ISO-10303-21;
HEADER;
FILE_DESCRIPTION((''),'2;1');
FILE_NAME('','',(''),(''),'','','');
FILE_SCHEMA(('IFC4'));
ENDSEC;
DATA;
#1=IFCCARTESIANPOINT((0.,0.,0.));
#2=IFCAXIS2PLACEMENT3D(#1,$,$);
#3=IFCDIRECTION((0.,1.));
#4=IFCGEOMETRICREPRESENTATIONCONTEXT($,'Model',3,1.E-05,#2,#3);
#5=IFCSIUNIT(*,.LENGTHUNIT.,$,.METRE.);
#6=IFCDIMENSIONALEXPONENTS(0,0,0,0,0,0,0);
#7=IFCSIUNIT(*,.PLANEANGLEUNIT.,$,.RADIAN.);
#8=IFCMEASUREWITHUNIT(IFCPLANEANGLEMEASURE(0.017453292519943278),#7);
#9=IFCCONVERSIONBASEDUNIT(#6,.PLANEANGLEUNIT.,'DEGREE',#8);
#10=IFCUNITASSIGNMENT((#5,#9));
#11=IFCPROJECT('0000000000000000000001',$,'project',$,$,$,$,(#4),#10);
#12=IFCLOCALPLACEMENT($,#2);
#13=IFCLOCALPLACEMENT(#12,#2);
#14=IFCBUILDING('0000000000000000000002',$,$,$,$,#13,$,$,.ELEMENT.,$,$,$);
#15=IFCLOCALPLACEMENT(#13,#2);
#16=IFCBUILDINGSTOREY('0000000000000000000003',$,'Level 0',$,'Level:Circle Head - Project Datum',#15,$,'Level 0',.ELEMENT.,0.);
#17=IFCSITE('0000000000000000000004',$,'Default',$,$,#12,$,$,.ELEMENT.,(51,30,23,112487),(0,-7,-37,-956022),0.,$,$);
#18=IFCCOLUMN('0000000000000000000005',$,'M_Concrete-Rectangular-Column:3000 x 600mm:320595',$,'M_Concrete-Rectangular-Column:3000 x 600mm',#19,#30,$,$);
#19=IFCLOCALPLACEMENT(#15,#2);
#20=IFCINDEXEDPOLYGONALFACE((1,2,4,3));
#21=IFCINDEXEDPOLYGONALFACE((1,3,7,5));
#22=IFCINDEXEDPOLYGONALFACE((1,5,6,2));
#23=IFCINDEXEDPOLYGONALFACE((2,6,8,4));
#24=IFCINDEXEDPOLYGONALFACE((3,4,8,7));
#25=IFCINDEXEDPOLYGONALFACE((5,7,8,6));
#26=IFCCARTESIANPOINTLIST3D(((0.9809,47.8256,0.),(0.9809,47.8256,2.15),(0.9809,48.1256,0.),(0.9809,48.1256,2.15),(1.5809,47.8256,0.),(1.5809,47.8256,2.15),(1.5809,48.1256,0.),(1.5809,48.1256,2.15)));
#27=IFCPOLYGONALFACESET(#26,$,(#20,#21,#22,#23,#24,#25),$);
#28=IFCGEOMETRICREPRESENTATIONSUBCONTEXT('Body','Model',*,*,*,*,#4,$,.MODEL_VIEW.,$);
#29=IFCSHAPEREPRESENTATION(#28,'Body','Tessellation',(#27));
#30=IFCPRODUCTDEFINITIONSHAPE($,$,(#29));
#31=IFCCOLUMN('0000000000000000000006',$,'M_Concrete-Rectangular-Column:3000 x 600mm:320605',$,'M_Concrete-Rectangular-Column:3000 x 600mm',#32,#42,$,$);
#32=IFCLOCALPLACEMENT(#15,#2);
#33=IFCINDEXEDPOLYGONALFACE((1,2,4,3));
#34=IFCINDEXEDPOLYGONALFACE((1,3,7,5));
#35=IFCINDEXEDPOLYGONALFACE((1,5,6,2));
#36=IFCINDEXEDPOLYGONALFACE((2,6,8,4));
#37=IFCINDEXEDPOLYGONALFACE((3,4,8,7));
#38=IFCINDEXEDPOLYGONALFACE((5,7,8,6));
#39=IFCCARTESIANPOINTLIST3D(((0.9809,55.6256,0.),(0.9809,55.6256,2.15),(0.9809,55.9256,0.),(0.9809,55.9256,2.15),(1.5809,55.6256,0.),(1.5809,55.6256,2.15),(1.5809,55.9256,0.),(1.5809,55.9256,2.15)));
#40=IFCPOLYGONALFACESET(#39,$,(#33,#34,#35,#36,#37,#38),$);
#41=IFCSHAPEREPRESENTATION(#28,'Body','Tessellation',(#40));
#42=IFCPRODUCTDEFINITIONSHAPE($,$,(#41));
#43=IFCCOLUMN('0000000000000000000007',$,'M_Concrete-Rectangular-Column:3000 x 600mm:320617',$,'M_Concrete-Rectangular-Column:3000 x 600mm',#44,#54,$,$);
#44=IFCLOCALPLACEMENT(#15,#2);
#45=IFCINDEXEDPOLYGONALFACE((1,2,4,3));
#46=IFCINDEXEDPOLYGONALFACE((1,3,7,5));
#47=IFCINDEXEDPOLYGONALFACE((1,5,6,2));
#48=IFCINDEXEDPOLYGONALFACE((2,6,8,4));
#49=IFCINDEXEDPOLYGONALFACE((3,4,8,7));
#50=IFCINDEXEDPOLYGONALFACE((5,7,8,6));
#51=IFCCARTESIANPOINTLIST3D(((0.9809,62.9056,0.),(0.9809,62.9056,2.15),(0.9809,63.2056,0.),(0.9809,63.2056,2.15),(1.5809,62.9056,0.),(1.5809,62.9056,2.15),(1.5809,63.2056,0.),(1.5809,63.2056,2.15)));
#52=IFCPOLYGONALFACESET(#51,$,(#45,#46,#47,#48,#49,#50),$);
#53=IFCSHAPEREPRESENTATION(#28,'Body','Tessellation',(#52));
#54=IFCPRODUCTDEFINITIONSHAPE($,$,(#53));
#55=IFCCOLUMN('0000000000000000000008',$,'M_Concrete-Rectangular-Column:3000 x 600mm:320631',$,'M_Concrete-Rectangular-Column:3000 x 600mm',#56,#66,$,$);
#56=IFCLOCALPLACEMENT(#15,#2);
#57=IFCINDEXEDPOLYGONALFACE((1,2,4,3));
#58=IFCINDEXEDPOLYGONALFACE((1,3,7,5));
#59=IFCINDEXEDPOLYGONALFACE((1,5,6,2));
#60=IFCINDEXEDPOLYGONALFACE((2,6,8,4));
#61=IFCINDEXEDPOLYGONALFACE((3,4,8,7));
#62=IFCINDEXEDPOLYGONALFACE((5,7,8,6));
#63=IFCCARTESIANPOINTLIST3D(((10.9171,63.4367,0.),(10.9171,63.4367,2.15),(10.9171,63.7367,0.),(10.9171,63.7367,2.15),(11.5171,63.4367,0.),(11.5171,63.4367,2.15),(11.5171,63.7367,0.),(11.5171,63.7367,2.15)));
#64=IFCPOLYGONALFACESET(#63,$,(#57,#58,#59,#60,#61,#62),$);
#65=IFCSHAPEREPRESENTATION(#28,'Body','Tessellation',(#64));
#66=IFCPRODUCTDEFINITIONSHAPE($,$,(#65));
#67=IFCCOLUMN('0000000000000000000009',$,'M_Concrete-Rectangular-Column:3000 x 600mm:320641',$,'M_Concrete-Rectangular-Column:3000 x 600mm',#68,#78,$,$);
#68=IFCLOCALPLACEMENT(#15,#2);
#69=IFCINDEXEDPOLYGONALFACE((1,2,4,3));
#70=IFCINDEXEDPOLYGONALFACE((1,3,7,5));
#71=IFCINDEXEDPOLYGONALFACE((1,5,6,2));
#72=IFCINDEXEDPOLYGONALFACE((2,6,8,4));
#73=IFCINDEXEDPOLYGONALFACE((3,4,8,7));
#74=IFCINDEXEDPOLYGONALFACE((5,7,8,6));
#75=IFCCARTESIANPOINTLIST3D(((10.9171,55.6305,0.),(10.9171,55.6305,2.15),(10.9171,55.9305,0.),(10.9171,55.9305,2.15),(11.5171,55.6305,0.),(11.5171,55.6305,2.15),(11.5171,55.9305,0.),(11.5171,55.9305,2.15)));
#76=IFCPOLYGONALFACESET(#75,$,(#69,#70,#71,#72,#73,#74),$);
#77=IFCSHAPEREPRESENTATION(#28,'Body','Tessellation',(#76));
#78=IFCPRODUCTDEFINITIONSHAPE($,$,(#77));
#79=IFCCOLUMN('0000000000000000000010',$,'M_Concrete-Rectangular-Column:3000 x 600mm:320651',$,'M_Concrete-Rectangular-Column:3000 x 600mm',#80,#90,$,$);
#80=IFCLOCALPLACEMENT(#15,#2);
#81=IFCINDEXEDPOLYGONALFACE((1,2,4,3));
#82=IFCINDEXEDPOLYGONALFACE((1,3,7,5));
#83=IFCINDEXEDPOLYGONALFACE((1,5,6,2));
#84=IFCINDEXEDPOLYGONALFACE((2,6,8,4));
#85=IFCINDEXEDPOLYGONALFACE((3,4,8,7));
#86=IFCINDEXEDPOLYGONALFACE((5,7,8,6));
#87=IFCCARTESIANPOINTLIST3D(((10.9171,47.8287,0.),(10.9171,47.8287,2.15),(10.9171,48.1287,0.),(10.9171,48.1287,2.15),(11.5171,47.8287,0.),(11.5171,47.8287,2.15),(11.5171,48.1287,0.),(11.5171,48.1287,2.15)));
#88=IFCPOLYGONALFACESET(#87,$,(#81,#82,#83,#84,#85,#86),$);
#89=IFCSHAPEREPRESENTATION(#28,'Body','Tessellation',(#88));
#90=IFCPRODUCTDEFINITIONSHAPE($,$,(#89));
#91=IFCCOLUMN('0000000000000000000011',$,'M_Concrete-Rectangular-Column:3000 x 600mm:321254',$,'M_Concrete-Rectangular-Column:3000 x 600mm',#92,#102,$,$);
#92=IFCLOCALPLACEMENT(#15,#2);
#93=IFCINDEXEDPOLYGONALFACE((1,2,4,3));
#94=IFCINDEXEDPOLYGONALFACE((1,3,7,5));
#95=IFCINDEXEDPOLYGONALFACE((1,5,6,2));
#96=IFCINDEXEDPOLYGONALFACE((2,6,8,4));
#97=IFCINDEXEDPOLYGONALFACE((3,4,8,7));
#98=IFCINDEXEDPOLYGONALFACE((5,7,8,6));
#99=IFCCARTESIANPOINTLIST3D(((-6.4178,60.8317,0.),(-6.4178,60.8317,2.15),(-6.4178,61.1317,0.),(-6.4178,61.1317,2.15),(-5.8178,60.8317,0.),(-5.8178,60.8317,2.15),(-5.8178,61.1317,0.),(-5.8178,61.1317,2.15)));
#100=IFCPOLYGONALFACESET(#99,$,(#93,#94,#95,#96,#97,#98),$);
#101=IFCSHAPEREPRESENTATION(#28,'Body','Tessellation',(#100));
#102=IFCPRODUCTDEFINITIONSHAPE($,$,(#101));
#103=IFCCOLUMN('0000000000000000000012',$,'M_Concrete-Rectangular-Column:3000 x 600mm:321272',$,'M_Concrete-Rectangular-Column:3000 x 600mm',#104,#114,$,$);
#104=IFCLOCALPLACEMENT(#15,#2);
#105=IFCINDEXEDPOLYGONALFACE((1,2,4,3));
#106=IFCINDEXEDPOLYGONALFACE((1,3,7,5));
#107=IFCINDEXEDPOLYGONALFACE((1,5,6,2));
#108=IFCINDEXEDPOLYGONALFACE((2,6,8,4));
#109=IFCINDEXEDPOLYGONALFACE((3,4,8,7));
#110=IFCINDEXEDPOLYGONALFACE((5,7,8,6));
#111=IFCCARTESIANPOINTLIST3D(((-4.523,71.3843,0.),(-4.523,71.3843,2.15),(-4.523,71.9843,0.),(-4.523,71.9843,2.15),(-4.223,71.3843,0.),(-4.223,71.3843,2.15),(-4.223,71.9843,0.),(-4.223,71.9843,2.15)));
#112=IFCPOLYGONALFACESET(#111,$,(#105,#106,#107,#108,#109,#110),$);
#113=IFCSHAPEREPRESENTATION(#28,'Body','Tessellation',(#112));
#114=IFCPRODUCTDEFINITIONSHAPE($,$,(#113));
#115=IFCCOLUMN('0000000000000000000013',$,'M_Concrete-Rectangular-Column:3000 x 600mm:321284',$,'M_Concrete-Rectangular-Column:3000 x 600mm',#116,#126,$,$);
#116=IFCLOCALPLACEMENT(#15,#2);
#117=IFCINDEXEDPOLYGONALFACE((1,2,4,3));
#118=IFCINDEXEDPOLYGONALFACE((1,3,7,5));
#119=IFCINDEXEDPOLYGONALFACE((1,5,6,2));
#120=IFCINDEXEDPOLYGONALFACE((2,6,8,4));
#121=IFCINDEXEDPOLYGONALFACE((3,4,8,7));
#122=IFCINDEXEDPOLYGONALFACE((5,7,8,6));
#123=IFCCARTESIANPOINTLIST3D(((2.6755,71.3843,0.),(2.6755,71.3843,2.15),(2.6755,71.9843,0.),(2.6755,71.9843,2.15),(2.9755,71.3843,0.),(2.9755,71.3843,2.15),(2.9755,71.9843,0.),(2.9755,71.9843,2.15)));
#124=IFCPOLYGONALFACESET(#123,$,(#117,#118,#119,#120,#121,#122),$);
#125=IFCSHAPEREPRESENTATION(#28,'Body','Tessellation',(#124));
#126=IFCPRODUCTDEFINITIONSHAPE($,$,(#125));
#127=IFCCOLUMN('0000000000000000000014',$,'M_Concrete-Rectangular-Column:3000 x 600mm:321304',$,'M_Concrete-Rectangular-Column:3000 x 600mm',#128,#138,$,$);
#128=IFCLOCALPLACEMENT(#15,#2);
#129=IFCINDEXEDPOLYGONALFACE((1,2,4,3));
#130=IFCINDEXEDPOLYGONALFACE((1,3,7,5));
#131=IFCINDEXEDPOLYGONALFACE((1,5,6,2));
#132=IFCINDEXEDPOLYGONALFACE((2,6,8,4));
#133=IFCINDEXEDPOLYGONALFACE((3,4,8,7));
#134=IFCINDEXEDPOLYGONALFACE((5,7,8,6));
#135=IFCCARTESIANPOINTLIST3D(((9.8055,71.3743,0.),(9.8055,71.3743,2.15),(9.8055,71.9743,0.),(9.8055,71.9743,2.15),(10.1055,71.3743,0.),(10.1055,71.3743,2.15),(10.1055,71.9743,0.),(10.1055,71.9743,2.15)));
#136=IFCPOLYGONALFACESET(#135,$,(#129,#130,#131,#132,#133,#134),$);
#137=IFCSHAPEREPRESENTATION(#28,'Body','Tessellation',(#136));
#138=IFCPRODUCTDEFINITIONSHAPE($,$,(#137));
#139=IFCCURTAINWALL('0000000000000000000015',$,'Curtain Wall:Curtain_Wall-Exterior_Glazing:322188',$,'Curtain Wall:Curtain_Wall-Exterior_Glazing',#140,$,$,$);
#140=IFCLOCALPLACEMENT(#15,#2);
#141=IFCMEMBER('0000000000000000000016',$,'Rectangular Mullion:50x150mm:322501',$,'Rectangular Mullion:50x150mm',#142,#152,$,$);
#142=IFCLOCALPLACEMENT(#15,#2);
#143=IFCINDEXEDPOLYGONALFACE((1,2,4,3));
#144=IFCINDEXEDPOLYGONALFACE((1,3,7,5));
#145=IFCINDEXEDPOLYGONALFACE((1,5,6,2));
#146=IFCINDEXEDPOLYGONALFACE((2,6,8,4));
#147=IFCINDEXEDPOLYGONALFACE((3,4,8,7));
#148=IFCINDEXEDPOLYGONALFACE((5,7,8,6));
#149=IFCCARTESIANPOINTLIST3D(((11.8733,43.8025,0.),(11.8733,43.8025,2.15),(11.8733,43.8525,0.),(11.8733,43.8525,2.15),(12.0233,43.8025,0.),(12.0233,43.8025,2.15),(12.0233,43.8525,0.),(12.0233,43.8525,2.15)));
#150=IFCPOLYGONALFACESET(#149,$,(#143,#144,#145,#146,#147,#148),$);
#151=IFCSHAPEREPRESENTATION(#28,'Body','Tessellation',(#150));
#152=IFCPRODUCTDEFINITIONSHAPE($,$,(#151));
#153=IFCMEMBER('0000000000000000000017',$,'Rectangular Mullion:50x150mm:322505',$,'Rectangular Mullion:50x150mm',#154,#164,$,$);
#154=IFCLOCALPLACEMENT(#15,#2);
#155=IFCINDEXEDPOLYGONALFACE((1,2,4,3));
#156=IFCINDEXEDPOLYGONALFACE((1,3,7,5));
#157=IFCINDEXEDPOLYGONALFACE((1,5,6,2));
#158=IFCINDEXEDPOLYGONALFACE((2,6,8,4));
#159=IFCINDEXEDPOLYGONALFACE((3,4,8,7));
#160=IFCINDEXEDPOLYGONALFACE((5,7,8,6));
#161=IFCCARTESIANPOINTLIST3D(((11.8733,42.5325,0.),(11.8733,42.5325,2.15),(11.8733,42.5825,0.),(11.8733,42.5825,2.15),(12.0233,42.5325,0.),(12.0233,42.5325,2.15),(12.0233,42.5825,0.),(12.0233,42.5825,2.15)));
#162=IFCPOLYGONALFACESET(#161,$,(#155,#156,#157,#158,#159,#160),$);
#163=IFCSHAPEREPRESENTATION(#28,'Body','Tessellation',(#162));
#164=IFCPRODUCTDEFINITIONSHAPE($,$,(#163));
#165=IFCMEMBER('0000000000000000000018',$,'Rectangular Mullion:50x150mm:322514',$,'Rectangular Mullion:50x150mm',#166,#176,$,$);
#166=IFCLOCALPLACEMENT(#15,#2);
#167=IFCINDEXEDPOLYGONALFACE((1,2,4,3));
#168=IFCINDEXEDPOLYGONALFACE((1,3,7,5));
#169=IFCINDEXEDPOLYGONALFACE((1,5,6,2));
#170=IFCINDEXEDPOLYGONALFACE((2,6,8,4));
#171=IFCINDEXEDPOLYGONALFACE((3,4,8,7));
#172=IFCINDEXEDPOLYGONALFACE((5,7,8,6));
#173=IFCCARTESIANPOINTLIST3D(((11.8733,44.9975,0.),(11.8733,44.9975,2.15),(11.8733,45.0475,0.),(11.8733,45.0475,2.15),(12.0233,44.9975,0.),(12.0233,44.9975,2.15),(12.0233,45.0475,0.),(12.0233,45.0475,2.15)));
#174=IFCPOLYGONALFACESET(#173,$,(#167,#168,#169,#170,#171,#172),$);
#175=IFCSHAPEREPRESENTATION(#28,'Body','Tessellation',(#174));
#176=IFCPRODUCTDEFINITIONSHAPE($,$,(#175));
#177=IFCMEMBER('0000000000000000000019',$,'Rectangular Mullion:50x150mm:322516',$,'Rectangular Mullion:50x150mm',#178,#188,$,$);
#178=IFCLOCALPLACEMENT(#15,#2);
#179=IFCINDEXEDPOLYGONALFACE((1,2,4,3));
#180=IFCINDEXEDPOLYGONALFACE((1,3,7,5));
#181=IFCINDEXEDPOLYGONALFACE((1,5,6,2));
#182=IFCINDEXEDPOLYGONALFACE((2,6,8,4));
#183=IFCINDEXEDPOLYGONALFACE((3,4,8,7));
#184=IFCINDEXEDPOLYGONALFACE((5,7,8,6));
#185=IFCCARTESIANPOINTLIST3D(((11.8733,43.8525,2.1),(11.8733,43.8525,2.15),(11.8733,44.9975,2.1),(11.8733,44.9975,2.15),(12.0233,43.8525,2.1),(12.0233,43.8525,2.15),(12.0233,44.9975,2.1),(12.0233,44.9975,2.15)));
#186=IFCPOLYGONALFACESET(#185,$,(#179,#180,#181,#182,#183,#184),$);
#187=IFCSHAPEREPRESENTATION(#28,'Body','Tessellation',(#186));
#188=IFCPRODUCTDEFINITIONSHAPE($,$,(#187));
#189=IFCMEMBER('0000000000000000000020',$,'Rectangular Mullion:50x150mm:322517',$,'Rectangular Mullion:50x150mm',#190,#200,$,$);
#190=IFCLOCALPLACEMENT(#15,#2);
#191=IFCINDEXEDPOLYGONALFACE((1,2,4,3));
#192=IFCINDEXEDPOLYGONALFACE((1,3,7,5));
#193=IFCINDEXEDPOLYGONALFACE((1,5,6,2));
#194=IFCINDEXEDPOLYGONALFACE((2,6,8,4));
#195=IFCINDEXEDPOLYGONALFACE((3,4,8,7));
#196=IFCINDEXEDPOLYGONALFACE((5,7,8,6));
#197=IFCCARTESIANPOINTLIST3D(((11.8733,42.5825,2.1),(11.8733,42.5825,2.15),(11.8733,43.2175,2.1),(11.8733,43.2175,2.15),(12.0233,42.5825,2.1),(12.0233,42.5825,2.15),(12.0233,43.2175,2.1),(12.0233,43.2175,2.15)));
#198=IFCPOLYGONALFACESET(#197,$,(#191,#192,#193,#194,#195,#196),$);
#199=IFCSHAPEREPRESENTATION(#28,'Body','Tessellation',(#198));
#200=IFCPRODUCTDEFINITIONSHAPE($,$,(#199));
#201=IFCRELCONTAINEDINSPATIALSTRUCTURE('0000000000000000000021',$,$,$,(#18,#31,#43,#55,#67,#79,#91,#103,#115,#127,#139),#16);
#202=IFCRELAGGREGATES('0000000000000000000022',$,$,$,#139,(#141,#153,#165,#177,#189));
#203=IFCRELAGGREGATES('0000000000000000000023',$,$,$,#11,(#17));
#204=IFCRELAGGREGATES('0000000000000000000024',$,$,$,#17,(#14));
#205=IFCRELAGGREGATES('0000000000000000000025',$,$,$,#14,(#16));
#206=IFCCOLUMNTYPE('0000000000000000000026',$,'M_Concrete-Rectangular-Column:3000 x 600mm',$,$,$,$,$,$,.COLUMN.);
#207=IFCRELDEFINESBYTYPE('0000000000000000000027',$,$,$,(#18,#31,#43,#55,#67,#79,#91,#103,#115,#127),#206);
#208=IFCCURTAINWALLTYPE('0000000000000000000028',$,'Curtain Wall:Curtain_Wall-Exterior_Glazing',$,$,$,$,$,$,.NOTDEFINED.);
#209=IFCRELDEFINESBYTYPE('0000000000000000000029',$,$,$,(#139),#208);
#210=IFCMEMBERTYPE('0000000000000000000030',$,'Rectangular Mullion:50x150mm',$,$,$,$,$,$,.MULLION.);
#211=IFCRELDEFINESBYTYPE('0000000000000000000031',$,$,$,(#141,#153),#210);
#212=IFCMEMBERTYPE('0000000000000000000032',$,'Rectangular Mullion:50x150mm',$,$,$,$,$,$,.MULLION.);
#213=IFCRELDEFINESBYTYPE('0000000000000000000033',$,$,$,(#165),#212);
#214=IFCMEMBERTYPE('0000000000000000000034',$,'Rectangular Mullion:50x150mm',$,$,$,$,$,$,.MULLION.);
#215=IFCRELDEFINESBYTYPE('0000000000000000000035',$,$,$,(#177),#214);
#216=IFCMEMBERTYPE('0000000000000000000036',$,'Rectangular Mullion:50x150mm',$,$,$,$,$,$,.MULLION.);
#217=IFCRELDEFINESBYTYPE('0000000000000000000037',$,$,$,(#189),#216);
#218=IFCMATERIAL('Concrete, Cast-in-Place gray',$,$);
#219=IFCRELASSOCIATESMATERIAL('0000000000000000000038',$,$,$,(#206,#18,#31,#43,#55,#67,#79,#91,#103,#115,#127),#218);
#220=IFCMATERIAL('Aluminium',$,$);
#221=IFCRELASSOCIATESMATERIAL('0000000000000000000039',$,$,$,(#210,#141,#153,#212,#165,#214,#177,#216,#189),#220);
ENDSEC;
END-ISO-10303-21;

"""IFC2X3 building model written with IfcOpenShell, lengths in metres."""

from ifc_helpers import new_model, entity, si_unit, converted_unit, direction, frame, origin, origin_2d_with_axis, place, context, subcontext, project, spatial, rectangle, extrude, source, transform, mapped, material, type_object, type_shapes, element, aggregate, save


model = new_model("IFC2X3")

# Units and contexts
model_context = context("Model", 3, precision=1e-05, world=origin(), true_north=direction((0.0, 1.0)))
body_context = subcontext(model_context, "Body", "Model", "MODEL_VIEW")
ifc_project = project(units=[si_unit("LENGTHUNIT", "METRE"), converted_unit("PLANEANGLEUNIT", "DEGREE", entity("IfcPlaneAngleMeasure", 0.017453292519943278), si_unit("PLANEANGLEUNIT", "RADIAN"), dimensions=[0, 0, 0, 0, 0, 0, 0])], contexts=[model_context])

# Site, building, storey
site_placement = place(None, origin())
site = spatial("IfcSite", under=ifc_project, at=site_placement, Name="Default", CompositionType="ELEMENT", RefLatitude=(51, 30, 23, 112487), RefLongitude=(0, -7, -37, -956022), RefElevation=0.0)
building_placement = place(site_placement, origin())
building = spatial("IfcBuilding", under=site, at=building_placement, CompositionType="ELEMENT")
storey_placement = place(building_placement, origin())
storey = spatial("IfcBuildingStorey", under=building, at=storey_placement, Name="Level 0", ObjectType="Level:Circle Head - Project Datum", LongName="Level 0", CompositionType="ELEMENT", Elevation=0.0)

# Columns
ifc_material_1 = material(Name="Concrete, Cast-in-Place gray")
column_type = type_object("IfcColumnType", Name="M_Concrete-Rectangular-Column:3000 x 600mm", PredefinedType="COLUMN", material=ifc_material_1)
shared_shape_1 = source(origin(), body_context, "Body", "SweptSolid", [
    extrude(rectangle(XDim=0.3, YDim=0.6, at=origin_2d_with_axis()), frame((0.0, 0.0, 0.0), z_axis=(0.0, 0.0, 1.0), x_axis=(-1.0, 0.0, 0.0)), (0.0, 0.0, 1.0), 2.15),
])
type_shapes(column_type, [shared_shape_1])
for number, where, z_axis, x_axis, name in (
    (1, (1.2809, 47.9756, 0.0), (0.0, 0.0, 1.0), (0.0, -1.0, 0.0), "M_Concrete-Rectangular-Column:3000 x 600mm:320595"),
    (2, (1.2809, 55.7756, 0.0), (0.0, 0.0, 1.0), (0.0, -1.0, 0.0), "M_Concrete-Rectangular-Column:3000 x 600mm:320605"),
    (3, (1.2809, 63.0556, 0.0), (0.0, 0.0, 1.0), (0.0, -1.0, 0.0), "M_Concrete-Rectangular-Column:3000 x 600mm:320617"),
    (4, (11.2171, 63.5867, 0.0), (0.0, 0.0, 1.0), (0.0, -1.0, 0.0), "M_Concrete-Rectangular-Column:3000 x 600mm:320631"),
    (5, (11.2171, 55.7805, 0.0), (0.0, 0.0, 1.0), (0.0, -1.0, 0.0), "M_Concrete-Rectangular-Column:3000 x 600mm:320641"),
    (6, (11.2171, 47.9787, 0.0), (0.0, 0.0, 1.0), (0.0, -1.0, 0.0), "M_Concrete-Rectangular-Column:3000 x 600mm:320651"),
    (7, (-6.1178, 60.9817, 0.0), (0.0, 0.0, 1.0), (0.0, -1.0, 0.0), "M_Concrete-Rectangular-Column:3000 x 600mm:321254"),
):
    element("IfcColumn", number, at=place(storey_placement, frame(where, z_axis=z_axis, x_axis=x_axis)), inside=storey, type_object=column_type, material=ifc_material_1, Name=name, ObjectType="M_Concrete-Rectangular-Column:3000 x 600mm", context=body_context, shape_type="MappedRepresentation", body=[
        mapped(shared_shape_1, transform((0.0, 0.0, 0.0), scale=1.0)),
    ])
for number, where, name in (
    (8, (-4.373, 71.6843, 0.0), "M_Concrete-Rectangular-Column:3000 x 600mm:321272"),
    (9, (2.8255, 71.6843, 0.0), "M_Concrete-Rectangular-Column:3000 x 600mm:321284"),
    (10, (9.9555, 71.6743, 0.0), "M_Concrete-Rectangular-Column:3000 x 600mm:321304"),
):
    element("IfcColumn", number, at=place(storey_placement, frame(where)), inside=storey, type_object=column_type, material=ifc_material_1, Name=name, ObjectType="M_Concrete-Rectangular-Column:3000 x 600mm", context=body_context, shape_type="MappedRepresentation", body=[
        mapped(shared_shape_1, transform((0.0, 0.0, 0.0), scale=1.0)),
    ])

# Curtain wall, members
curtain_wall_type = type_object("IfcCurtainWallType", Name="Curtain Wall:Curtain_Wall-Exterior_Glazing", PredefinedType="NOTDEFINED")
curtain_wall_placement = place(storey_placement, origin())
curtain_wall = element("IfcCurtainWall", 11, at=curtain_wall_placement, inside=storey, type_object=curtain_wall_type, Name="Curtain Wall:Curtain_Wall-Exterior_Glazing:322188", ObjectType="Curtain Wall:Curtain_Wall-Exterior_Glazing")
ifc_material_2 = material(Name="Aluminium")
member_type_1 = type_object("IfcMemberType", Name="Rectangular Mullion:50x150mm", PredefinedType="MULLION", material=ifc_material_2)
shared_shape_2 = source(origin(), body_context, "Body", "SweptSolid", [
    extrude(rectangle(XDim=0.05, YDim=0.15, at=origin_2d_with_axis()), frame((0.0, 0.0, -2.15), z_axis=(0.0, 0.0, 1.0), x_axis=(-1.0, 0.0, 0.0)), (0.0, 0.0, 1.0), 2.15),
])
type_shapes(member_type_1, [shared_shape_2])
member_1_placement = place(curtain_wall_placement, frame((11.9483, 43.8275, 0.0), z_axis=(0.0, 0.0, -1.0), x_axis=(0.0, -1.0, 0.0)))
member_1 = element("IfcMember", 12, at=member_1_placement, type_object=member_type_1, material=ifc_material_2, Name="Rectangular Mullion:50x150mm:322501", ObjectType="Rectangular Mullion:50x150mm", context=body_context, shape_type="MappedRepresentation", body=[
    mapped(shared_shape_2, transform((0.0, 0.0, 0.0), scale=1.0)),
])
member_2_placement = place(curtain_wall_placement, frame((11.9483, 42.5575, 0.0), z_axis=(0.0, 0.0, -1.0), x_axis=(0.0, -1.0, 0.0)))
member_2 = element("IfcMember", 13, at=member_2_placement, type_object=member_type_1, material=ifc_material_2, Name="Rectangular Mullion:50x150mm:322505", ObjectType="Rectangular Mullion:50x150mm", context=body_context, shape_type="MappedRepresentation", body=[
    mapped(shared_shape_2, transform((0.0, 0.0, 0.0), scale=1.0)),
])
member_type_2 = type_object("IfcMemberType", Name="Rectangular Mullion:50x150mm", PredefinedType="MULLION", material=ifc_material_2)
shared_shape_3 = source(origin(), body_context, "Body", "SweptSolid", [
    extrude(rectangle(XDim=0.05, YDim=0.15, at=origin_2d_with_axis()), frame((-0.025, 0.0, -2.15), z_axis=(0.0, 0.0, 1.0), x_axis=(-1.0, 0.0, 0.0)), (0.0, 0.0, 1.0), 2.15),
])
type_shapes(member_type_2, [shared_shape_3])
member_3_placement = place(curtain_wall_placement, frame((11.9483, 45.0475, 2.15), z_axis=(0.0, 0.0, 1.0), x_axis=(0.0, 1.0, 0.0)))
member_3 = element("IfcMember", 14, at=member_3_placement, type_object=member_type_2, material=ifc_material_2, Name="Rectangular Mullion:50x150mm:322514", ObjectType="Rectangular Mullion:50x150mm", context=body_context, shape_type="MappedRepresentation", body=[
    mapped(shared_shape_3, transform((0.0, 0.0, 0.0), scale=1.0)),
])
member_type_3 = type_object("IfcMemberType", Name="Rectangular Mullion:50x150mm", PredefinedType="MULLION", material=ifc_material_2)
shared_shape_4 = source(origin(), body_context, "Body", "SweptSolid", [
    extrude(rectangle(XDim=0.05, YDim=0.15, at=origin_2d_with_axis()), frame((-0.025, 0.0, -1.145), z_axis=(0.0, 0.0, 1.0), x_axis=(-1.0, 0.0, 0.0)), (0.0, 0.0, 1.0), 1.145),
])
type_shapes(member_type_3, [shared_shape_4])
member_4_placement = place(curtain_wall_placement, frame((11.9483, 43.8525, 2.15), z_axis=(0.0, -1.0, 0.0), x_axis=(0.0, 0.0, 1.0)))
member_4 = element("IfcMember", 15, at=member_4_placement, type_object=member_type_3, material=ifc_material_2, Name="Rectangular Mullion:50x150mm:322516", ObjectType="Rectangular Mullion:50x150mm", context=body_context, shape_type="MappedRepresentation", body=[
    mapped(shared_shape_4, transform((0.0, 0.0, 0.0), scale=1.0)),
])
member_type_4 = type_object("IfcMemberType", Name="Rectangular Mullion:50x150mm", PredefinedType="MULLION", material=ifc_material_2)
shared_shape_5 = source(origin(), body_context, "Body", "SweptSolid", [
    extrude(rectangle(XDim=0.05, YDim=0.15, at=origin_2d_with_axis()), frame((-0.025, 0.0, -0.635), z_axis=(0.0, 0.0, 1.0), x_axis=(-1.0, 0.0, 0.0)), (0.0, 0.0, 1.0), 0.635),
])
type_shapes(member_type_4, [shared_shape_5])
member_5_placement = place(curtain_wall_placement, frame((11.9483, 42.5825, 2.15), z_axis=(0.0, -1.0, 0.0), x_axis=(0.0, 0.0, 1.0)))
member_5 = element("IfcMember", 16, at=member_5_placement, type_object=member_type_4, material=ifc_material_2, Name="Rectangular Mullion:50x150mm:322517", ObjectType="Rectangular Mullion:50x150mm", context=body_context, shape_type="MappedRepresentation", body=[
    mapped(shared_shape_5, transform((0.0, 0.0, 0.0), scale=1.0)),
])
aggregate(curtain_wall, [member_1, member_2, member_3, member_4, member_5])

save(model, "model.ifc")
